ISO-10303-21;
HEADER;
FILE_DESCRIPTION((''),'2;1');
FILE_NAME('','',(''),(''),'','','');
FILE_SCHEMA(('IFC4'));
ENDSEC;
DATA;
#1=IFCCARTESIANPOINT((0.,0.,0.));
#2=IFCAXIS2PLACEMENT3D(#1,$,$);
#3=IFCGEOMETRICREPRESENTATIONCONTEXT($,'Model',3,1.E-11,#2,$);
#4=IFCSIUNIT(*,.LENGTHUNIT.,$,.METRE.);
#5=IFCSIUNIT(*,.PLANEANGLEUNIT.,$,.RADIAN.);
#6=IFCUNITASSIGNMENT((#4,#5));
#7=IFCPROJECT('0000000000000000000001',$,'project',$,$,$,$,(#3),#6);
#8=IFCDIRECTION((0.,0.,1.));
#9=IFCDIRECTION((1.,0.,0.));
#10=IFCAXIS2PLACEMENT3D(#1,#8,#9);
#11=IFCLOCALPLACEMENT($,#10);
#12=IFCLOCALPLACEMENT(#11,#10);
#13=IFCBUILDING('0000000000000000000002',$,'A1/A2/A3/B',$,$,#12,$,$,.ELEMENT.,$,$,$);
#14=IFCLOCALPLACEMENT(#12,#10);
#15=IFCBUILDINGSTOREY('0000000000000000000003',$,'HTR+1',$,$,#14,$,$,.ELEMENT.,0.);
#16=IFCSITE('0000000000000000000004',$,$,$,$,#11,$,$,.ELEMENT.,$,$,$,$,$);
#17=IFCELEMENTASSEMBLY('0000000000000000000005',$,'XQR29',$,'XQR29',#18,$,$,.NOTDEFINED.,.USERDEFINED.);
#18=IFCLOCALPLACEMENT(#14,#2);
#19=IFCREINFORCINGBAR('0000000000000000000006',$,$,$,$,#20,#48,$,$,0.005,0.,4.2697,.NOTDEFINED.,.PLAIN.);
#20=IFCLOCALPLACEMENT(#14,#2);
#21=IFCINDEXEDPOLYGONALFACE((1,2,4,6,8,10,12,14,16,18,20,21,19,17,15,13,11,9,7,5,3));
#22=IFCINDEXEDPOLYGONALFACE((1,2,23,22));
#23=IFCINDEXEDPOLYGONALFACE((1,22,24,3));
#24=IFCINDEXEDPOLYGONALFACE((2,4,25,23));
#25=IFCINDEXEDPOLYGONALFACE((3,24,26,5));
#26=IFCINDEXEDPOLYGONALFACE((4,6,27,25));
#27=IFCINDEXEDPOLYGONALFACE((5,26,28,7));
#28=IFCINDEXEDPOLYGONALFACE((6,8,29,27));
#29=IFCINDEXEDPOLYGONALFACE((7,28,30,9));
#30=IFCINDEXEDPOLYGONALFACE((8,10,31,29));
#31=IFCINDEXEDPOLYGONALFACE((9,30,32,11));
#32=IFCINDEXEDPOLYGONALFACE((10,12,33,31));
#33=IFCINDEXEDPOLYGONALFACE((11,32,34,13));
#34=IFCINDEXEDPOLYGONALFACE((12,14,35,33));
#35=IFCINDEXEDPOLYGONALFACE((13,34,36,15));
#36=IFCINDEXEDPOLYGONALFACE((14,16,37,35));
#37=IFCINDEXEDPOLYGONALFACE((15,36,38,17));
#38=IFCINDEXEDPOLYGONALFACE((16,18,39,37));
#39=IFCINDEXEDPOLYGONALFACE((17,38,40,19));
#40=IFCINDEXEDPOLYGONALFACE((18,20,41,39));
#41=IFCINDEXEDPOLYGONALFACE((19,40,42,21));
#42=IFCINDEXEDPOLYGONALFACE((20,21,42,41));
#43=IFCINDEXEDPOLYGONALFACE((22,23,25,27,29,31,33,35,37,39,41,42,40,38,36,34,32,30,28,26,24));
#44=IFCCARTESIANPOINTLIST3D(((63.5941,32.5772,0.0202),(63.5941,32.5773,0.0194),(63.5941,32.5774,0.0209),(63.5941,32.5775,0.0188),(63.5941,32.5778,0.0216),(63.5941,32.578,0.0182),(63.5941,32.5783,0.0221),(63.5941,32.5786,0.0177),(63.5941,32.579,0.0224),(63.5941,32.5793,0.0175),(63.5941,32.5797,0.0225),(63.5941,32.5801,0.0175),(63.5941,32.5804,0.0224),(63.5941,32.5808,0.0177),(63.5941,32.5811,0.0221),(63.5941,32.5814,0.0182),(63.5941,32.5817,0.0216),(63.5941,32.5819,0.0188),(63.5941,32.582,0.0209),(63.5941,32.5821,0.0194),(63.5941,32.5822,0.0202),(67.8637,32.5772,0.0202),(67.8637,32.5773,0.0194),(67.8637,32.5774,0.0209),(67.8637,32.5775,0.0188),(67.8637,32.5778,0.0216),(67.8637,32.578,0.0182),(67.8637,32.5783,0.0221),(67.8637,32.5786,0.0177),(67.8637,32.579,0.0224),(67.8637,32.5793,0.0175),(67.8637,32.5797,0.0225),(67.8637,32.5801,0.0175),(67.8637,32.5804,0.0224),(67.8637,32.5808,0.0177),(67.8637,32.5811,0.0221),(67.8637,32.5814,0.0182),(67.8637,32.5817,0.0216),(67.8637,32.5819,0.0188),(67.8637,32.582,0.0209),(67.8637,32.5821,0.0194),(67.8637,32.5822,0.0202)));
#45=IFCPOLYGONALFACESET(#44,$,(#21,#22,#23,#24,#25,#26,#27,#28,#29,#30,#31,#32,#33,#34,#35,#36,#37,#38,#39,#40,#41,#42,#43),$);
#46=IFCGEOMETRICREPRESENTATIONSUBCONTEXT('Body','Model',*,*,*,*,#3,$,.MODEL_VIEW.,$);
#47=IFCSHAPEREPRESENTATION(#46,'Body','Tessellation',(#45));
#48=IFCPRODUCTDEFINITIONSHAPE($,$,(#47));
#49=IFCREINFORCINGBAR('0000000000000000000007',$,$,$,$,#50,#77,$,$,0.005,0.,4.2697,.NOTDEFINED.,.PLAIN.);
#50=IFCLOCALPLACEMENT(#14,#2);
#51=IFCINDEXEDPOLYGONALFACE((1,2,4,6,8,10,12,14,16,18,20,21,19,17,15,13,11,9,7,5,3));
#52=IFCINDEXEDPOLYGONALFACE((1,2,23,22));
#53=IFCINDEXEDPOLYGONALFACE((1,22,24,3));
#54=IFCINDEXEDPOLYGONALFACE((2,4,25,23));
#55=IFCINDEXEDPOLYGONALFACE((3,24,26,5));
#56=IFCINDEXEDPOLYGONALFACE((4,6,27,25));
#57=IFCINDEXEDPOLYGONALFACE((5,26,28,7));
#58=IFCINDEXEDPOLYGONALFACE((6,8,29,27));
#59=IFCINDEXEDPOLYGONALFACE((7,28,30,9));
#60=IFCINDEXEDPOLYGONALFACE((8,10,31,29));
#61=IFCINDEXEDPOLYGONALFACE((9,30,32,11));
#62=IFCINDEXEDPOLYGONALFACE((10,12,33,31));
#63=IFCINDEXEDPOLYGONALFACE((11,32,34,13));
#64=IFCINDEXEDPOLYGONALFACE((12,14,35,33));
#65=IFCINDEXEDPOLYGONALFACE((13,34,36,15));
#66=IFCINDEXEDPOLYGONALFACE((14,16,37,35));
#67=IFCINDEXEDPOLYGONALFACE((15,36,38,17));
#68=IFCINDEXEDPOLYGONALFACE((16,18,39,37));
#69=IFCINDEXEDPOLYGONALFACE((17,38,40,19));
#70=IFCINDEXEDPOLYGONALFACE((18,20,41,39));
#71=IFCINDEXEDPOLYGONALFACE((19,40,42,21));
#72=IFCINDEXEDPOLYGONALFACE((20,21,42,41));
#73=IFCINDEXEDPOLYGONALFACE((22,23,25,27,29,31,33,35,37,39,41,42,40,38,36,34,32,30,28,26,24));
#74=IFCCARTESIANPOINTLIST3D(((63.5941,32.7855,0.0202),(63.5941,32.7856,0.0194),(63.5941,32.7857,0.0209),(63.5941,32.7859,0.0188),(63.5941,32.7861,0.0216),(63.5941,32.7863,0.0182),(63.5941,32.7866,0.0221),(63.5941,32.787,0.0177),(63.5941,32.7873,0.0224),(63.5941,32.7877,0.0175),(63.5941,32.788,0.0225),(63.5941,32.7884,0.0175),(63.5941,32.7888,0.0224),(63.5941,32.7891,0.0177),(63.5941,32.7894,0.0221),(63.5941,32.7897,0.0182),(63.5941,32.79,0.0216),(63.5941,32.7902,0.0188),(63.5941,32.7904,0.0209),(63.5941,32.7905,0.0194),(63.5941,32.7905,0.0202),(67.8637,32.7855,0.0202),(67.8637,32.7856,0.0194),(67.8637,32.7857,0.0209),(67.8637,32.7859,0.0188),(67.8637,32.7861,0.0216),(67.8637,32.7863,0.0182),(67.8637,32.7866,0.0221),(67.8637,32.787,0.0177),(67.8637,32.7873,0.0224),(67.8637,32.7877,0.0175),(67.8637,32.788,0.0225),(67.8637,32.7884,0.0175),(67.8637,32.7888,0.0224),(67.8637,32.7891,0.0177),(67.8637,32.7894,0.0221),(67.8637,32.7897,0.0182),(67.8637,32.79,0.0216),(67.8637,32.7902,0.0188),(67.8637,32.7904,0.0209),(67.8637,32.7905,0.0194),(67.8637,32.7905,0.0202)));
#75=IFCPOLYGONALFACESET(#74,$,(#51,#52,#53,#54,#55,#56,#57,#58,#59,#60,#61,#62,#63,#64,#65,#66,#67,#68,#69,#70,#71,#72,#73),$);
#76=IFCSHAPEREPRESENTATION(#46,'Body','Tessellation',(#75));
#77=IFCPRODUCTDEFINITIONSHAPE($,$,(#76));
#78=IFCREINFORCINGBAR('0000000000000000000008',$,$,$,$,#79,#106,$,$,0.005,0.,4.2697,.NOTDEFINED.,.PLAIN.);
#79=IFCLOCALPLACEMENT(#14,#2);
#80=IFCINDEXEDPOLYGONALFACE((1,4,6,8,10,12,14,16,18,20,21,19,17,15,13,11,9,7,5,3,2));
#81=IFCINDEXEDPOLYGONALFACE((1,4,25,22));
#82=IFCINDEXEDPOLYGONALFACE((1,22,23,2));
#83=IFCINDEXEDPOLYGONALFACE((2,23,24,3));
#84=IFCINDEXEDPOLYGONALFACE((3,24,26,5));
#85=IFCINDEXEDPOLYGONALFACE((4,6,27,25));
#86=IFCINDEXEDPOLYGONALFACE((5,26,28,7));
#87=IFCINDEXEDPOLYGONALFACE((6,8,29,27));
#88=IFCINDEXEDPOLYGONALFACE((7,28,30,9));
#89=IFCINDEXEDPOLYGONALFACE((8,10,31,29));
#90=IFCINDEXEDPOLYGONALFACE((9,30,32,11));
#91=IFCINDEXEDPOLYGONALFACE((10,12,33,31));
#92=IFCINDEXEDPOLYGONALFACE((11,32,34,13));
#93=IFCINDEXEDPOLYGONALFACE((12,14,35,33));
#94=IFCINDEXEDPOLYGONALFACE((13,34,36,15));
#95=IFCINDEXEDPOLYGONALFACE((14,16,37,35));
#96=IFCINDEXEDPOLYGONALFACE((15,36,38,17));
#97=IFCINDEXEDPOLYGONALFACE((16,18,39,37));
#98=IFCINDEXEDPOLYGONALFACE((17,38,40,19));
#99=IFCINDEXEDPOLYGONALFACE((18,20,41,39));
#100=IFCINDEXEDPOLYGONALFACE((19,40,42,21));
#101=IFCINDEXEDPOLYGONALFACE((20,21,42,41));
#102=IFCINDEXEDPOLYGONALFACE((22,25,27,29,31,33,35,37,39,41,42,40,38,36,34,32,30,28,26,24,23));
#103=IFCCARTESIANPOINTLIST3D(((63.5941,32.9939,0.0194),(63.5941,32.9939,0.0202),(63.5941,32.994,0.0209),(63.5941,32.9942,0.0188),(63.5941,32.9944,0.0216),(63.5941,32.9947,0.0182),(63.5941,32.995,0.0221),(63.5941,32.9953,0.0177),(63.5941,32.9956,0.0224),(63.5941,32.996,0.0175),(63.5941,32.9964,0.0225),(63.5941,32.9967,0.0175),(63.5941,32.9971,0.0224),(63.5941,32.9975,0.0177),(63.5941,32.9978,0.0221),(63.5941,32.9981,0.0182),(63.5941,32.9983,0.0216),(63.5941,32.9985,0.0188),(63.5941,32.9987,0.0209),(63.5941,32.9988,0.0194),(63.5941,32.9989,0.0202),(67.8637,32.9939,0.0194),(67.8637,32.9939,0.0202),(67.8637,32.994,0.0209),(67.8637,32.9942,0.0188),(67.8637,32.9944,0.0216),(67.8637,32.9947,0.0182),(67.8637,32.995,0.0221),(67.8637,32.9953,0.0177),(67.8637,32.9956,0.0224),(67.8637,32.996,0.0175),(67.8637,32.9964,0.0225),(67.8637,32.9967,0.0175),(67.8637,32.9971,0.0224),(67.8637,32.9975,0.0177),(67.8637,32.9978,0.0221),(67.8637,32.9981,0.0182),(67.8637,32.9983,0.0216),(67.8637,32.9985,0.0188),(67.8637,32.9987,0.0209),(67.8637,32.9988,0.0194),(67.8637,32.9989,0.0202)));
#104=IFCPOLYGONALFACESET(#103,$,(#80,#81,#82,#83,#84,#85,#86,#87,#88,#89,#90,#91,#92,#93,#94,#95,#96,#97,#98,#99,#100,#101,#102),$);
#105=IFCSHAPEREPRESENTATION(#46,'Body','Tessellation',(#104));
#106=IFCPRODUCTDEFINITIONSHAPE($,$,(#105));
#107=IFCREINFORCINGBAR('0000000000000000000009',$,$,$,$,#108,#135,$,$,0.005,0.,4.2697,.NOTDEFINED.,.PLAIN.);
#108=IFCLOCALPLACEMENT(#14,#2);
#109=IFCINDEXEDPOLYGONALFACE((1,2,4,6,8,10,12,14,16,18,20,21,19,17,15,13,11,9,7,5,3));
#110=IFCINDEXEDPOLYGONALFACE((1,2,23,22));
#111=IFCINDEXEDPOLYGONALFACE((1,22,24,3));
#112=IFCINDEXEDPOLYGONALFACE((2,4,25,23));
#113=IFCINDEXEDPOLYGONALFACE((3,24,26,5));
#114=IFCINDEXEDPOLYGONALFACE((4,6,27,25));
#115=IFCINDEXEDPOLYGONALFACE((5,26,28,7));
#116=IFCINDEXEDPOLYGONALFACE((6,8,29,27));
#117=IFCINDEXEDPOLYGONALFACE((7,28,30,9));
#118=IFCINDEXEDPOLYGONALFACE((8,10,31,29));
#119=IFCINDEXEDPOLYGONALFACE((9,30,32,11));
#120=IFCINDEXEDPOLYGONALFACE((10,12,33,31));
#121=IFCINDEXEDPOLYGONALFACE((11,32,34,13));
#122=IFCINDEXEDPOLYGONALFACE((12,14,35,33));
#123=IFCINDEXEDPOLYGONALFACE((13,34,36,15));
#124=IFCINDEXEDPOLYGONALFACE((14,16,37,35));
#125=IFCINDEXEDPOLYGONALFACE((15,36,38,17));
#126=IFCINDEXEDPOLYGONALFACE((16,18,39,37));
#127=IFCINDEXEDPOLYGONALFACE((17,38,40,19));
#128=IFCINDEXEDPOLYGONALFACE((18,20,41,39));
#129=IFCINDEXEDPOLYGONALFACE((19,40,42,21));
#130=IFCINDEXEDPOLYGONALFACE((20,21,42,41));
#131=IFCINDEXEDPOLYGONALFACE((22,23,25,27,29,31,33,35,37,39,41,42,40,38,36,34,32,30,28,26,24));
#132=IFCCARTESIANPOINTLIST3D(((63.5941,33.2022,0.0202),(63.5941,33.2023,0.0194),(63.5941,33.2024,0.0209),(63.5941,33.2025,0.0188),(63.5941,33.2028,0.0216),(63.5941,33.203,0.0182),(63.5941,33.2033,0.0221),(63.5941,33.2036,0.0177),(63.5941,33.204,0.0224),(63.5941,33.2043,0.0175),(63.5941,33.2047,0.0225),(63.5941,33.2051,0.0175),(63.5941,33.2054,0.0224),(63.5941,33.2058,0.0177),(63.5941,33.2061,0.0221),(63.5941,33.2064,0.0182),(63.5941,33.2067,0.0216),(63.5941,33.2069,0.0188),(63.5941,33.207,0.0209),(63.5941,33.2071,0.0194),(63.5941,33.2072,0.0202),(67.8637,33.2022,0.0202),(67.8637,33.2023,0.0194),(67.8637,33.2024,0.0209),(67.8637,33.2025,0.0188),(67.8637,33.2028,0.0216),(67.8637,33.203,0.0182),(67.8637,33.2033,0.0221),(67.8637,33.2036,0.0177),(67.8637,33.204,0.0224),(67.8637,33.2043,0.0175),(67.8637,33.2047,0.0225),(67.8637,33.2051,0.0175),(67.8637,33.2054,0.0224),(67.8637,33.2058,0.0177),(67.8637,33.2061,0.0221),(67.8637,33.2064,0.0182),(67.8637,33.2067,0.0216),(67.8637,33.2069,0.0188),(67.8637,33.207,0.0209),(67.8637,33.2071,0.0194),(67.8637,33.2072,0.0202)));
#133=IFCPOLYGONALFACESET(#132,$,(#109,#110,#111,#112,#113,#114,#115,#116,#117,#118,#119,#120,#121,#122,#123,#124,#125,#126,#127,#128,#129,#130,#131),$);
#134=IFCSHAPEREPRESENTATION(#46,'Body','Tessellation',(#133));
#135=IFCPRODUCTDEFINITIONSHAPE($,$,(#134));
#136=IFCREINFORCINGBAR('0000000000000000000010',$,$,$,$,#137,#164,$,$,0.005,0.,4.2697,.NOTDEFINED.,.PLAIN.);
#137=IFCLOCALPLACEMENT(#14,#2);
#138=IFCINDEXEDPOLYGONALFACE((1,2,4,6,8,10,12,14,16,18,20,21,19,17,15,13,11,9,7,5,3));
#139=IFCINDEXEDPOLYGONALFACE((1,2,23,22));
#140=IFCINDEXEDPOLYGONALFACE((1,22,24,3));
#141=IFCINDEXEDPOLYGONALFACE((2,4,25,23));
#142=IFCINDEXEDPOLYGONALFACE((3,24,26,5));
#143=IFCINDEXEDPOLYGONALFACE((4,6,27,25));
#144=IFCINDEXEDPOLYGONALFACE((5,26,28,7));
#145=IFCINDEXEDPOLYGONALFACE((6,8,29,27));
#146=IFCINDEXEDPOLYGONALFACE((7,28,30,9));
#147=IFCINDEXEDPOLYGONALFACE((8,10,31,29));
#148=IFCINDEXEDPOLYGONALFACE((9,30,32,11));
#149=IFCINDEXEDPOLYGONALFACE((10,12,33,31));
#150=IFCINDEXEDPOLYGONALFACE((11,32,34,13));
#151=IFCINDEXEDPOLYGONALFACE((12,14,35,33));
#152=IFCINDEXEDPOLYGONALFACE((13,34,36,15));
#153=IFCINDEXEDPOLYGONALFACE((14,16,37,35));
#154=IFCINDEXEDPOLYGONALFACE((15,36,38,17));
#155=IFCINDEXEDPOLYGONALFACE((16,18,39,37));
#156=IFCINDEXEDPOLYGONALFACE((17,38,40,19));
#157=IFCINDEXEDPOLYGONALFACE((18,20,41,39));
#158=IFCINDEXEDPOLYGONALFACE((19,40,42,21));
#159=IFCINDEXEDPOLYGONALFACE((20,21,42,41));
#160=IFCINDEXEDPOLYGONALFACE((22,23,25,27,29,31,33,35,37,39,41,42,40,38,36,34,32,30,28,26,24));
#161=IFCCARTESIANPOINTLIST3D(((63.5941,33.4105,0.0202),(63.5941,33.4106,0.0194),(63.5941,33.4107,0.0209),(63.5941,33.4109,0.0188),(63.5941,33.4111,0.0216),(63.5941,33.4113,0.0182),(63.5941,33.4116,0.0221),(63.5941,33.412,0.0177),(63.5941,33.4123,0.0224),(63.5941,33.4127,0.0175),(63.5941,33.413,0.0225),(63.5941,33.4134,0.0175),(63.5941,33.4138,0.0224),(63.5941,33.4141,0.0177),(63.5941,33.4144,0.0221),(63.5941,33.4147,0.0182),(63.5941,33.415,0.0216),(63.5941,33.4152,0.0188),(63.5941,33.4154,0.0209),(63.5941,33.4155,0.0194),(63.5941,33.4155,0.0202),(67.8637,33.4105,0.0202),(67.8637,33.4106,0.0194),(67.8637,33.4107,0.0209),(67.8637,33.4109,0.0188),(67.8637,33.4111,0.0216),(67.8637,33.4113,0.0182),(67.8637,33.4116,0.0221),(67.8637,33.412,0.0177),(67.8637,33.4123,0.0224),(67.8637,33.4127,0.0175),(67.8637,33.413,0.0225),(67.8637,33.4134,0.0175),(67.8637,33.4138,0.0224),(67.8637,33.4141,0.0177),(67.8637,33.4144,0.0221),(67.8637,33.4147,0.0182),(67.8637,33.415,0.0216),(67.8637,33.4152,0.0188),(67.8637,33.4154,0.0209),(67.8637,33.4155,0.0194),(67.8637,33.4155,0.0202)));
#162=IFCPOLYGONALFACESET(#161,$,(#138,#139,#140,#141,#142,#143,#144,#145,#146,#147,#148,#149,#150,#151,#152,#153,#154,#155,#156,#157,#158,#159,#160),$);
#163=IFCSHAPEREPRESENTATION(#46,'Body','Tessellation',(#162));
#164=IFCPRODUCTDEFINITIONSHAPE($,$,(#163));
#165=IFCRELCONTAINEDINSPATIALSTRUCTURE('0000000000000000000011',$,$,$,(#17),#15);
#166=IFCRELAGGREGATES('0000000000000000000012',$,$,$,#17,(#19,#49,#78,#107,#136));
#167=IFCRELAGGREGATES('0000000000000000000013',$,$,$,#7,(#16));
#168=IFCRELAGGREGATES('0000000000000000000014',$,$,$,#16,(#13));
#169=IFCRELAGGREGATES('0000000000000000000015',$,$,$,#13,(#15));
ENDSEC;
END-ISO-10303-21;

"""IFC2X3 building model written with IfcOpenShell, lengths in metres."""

from ifc_helpers import new_model, entity, si_unit, origin, origin_with_axes, place, context, subcontext, project, spatial, shape, element, aggregate, save


model = new_model("IFC2X3")

# Units and contexts
model_context = context("Model", 3, precision=1e-11, world=origin())
body_context = subcontext(model_context, "Body", "Model", "MODEL_VIEW")
ifc_project = project(units=[si_unit("LENGTHUNIT", "METRE"), si_unit("PLANEANGLEUNIT", "RADIAN")], contexts=[model_context])

# Site, building, storey
site_placement = place(None, origin_with_axes())
site = spatial("IfcSite", under=ifc_project, at=site_placement, CompositionType="ELEMENT")
building_placement = place(site_placement, origin_with_axes())
building = spatial("IfcBuilding", under=site, at=building_placement, Name="A1/A2/A3/B", CompositionType="ELEMENT")
storey_placement = place(building_placement, origin_with_axes())
storey = spatial("IfcBuildingStorey", under=building, at=storey_placement, Name="HTR+1", CompositionType="ELEMENT", Elevation=0.0)

# Element assembly, reinforcing bars
assembly_1_placement = place(storey_placement, origin_with_axes())
assembly_1 = element("IfcElementAssembly", 1, at=assembly_1_placement, inside=storey, Name="XQR29", ObjectType="XQR29", AssemblyPlace="NOTDEFINED", PredefinedType="USERDEFINED")
reinforcing_bar_1_placement = place(assembly_1_placement, origin_with_axes())
reinforcing_bar_1 = element("IfcReinforcingBar", 2, at=reinforcing_bar_1_placement, BarLength=4.2697, BarRole="NOTDEFINED", BarSurface="PLAIN", CrossSectionArea=0.0, NominalDiameter=0.005, shapes=[
    shape(body_context, "Body", "AdvancedSweptSolid", [entity("IfcSweptDiskSolid", entity("IfcPolyline", [entity("IfcCartesianPoint", [63.5941, 32.5797, 0.02]), entity("IfcCartesianPoint", [67.8637, 32.5797, 0.02])]), 0.0025, None, 0.0, 4.2697)]),
    shape(body_context, "Body", "AdvancedSweptSolid", [entity("IfcSweptDiskSolid", entity("IfcPolyline", [entity("IfcCartesianPoint", [63.5941, 32.5797, 0.02]), entity("IfcCartesianPoint", [67.8637, 32.5797, 0.02])]), 0.0025, None, 0.0, 4.2697)]),
])
reinforcing_bar_2_placement = place(assembly_1_placement, origin_with_axes())
reinforcing_bar_2 = element("IfcReinforcingBar", 3, at=reinforcing_bar_2_placement, BarLength=4.2697, BarRole="NOTDEFINED", BarSurface="PLAIN", CrossSectionArea=0.0, NominalDiameter=0.005, shapes=[
    shape(body_context, "Body", "AdvancedSweptSolid", [entity("IfcSweptDiskSolid", entity("IfcPolyline", [entity("IfcCartesianPoint", [63.5941, 32.788, 0.02]), entity("IfcCartesianPoint", [67.8637, 32.788, 0.02])]), 0.0025, None, 0.0, 4.2697)]),
    shape(body_context, "Body", "AdvancedSweptSolid", [entity("IfcSweptDiskSolid", entity("IfcPolyline", [entity("IfcCartesianPoint", [63.5941, 32.788, 0.02]), entity("IfcCartesianPoint", [67.8637, 32.788, 0.02])]), 0.0025, None, 0.0, 4.2697)]),
])
reinforcing_bar_3_placement = place(assembly_1_placement, origin_with_axes())
reinforcing_bar_3 = element("IfcReinforcingBar", 4, at=reinforcing_bar_3_placement, BarLength=4.2697, BarRole="NOTDEFINED", BarSurface="PLAIN", CrossSectionArea=0.0, NominalDiameter=0.005, shapes=[
    shape(body_context, "Body", "AdvancedSweptSolid", [entity("IfcSweptDiskSolid", entity("IfcPolyline", [entity("IfcCartesianPoint", [63.5941, 32.9964, 0.02]), entity("IfcCartesianPoint", [67.8637, 32.9964, 0.02])]), 0.0025, None, 0.0, 4.2697)]),
    shape(body_context, "Body", "AdvancedSweptSolid", [entity("IfcSweptDiskSolid", entity("IfcPolyline", [entity("IfcCartesianPoint", [63.5941, 32.9964, 0.02]), entity("IfcCartesianPoint", [67.8637, 32.9964, 0.02])]), 0.0025, None, 0.0, 4.2697)]),
])
reinforcing_bar_4_placement = place(assembly_1_placement, origin_with_axes())
reinforcing_bar_4 = element("IfcReinforcingBar", 5, at=reinforcing_bar_4_placement, BarLength=4.2697, BarRole="NOTDEFINED", BarSurface="PLAIN", CrossSectionArea=0.0, NominalDiameter=0.005, shapes=[
    shape(body_context, "Body", "AdvancedSweptSolid", [entity("IfcSweptDiskSolid", entity("IfcPolyline", [entity("IfcCartesianPoint", [63.5941, 33.2047, 0.02]), entity("IfcCartesianPoint", [67.8637, 33.2047, 0.02])]), 0.0025, None, 0.0, 4.2697)]),
    shape(body_context, "Body", "AdvancedSweptSolid", [entity("IfcSweptDiskSolid", entity("IfcPolyline", [entity("IfcCartesianPoint", [63.5941, 33.2047, 0.02]), entity("IfcCartesianPoint", [67.8637, 33.2047, 0.02])]), 0.0025, None, 0.0, 4.2697)]),
])
reinforcing_bar_5_placement = place(assembly_1_placement, origin_with_axes())
reinforcing_bar_5 = element("IfcReinforcingBar", 6, at=reinforcing_bar_5_placement, BarLength=4.2697, BarRole="NOTDEFINED", BarSurface="PLAIN", CrossSectionArea=0.0, NominalDiameter=0.005, shapes=[
    shape(body_context, "Body", "AdvancedSweptSolid", [entity("IfcSweptDiskSolid", entity("IfcPolyline", [entity("IfcCartesianPoint", [63.5941, 33.413, 0.02]), entity("IfcCartesianPoint", [67.8637, 33.413, 0.02])]), 0.0025, None, 0.0, 4.2697)]),
    shape(body_context, "Body", "AdvancedSweptSolid", [entity("IfcSweptDiskSolid", entity("IfcPolyline", [entity("IfcCartesianPoint", [63.5941, 33.413, 0.02]), entity("IfcCartesianPoint", [67.8637, 33.413, 0.02])]), 0.0025, None, 0.0, 4.2697)]),
])
aggregate(assembly_1, [reinforcing_bar_1, reinforcing_bar_2, reinforcing_bar_3, reinforcing_bar_4, reinforcing_bar_5])

save(model, "model.ifc")
